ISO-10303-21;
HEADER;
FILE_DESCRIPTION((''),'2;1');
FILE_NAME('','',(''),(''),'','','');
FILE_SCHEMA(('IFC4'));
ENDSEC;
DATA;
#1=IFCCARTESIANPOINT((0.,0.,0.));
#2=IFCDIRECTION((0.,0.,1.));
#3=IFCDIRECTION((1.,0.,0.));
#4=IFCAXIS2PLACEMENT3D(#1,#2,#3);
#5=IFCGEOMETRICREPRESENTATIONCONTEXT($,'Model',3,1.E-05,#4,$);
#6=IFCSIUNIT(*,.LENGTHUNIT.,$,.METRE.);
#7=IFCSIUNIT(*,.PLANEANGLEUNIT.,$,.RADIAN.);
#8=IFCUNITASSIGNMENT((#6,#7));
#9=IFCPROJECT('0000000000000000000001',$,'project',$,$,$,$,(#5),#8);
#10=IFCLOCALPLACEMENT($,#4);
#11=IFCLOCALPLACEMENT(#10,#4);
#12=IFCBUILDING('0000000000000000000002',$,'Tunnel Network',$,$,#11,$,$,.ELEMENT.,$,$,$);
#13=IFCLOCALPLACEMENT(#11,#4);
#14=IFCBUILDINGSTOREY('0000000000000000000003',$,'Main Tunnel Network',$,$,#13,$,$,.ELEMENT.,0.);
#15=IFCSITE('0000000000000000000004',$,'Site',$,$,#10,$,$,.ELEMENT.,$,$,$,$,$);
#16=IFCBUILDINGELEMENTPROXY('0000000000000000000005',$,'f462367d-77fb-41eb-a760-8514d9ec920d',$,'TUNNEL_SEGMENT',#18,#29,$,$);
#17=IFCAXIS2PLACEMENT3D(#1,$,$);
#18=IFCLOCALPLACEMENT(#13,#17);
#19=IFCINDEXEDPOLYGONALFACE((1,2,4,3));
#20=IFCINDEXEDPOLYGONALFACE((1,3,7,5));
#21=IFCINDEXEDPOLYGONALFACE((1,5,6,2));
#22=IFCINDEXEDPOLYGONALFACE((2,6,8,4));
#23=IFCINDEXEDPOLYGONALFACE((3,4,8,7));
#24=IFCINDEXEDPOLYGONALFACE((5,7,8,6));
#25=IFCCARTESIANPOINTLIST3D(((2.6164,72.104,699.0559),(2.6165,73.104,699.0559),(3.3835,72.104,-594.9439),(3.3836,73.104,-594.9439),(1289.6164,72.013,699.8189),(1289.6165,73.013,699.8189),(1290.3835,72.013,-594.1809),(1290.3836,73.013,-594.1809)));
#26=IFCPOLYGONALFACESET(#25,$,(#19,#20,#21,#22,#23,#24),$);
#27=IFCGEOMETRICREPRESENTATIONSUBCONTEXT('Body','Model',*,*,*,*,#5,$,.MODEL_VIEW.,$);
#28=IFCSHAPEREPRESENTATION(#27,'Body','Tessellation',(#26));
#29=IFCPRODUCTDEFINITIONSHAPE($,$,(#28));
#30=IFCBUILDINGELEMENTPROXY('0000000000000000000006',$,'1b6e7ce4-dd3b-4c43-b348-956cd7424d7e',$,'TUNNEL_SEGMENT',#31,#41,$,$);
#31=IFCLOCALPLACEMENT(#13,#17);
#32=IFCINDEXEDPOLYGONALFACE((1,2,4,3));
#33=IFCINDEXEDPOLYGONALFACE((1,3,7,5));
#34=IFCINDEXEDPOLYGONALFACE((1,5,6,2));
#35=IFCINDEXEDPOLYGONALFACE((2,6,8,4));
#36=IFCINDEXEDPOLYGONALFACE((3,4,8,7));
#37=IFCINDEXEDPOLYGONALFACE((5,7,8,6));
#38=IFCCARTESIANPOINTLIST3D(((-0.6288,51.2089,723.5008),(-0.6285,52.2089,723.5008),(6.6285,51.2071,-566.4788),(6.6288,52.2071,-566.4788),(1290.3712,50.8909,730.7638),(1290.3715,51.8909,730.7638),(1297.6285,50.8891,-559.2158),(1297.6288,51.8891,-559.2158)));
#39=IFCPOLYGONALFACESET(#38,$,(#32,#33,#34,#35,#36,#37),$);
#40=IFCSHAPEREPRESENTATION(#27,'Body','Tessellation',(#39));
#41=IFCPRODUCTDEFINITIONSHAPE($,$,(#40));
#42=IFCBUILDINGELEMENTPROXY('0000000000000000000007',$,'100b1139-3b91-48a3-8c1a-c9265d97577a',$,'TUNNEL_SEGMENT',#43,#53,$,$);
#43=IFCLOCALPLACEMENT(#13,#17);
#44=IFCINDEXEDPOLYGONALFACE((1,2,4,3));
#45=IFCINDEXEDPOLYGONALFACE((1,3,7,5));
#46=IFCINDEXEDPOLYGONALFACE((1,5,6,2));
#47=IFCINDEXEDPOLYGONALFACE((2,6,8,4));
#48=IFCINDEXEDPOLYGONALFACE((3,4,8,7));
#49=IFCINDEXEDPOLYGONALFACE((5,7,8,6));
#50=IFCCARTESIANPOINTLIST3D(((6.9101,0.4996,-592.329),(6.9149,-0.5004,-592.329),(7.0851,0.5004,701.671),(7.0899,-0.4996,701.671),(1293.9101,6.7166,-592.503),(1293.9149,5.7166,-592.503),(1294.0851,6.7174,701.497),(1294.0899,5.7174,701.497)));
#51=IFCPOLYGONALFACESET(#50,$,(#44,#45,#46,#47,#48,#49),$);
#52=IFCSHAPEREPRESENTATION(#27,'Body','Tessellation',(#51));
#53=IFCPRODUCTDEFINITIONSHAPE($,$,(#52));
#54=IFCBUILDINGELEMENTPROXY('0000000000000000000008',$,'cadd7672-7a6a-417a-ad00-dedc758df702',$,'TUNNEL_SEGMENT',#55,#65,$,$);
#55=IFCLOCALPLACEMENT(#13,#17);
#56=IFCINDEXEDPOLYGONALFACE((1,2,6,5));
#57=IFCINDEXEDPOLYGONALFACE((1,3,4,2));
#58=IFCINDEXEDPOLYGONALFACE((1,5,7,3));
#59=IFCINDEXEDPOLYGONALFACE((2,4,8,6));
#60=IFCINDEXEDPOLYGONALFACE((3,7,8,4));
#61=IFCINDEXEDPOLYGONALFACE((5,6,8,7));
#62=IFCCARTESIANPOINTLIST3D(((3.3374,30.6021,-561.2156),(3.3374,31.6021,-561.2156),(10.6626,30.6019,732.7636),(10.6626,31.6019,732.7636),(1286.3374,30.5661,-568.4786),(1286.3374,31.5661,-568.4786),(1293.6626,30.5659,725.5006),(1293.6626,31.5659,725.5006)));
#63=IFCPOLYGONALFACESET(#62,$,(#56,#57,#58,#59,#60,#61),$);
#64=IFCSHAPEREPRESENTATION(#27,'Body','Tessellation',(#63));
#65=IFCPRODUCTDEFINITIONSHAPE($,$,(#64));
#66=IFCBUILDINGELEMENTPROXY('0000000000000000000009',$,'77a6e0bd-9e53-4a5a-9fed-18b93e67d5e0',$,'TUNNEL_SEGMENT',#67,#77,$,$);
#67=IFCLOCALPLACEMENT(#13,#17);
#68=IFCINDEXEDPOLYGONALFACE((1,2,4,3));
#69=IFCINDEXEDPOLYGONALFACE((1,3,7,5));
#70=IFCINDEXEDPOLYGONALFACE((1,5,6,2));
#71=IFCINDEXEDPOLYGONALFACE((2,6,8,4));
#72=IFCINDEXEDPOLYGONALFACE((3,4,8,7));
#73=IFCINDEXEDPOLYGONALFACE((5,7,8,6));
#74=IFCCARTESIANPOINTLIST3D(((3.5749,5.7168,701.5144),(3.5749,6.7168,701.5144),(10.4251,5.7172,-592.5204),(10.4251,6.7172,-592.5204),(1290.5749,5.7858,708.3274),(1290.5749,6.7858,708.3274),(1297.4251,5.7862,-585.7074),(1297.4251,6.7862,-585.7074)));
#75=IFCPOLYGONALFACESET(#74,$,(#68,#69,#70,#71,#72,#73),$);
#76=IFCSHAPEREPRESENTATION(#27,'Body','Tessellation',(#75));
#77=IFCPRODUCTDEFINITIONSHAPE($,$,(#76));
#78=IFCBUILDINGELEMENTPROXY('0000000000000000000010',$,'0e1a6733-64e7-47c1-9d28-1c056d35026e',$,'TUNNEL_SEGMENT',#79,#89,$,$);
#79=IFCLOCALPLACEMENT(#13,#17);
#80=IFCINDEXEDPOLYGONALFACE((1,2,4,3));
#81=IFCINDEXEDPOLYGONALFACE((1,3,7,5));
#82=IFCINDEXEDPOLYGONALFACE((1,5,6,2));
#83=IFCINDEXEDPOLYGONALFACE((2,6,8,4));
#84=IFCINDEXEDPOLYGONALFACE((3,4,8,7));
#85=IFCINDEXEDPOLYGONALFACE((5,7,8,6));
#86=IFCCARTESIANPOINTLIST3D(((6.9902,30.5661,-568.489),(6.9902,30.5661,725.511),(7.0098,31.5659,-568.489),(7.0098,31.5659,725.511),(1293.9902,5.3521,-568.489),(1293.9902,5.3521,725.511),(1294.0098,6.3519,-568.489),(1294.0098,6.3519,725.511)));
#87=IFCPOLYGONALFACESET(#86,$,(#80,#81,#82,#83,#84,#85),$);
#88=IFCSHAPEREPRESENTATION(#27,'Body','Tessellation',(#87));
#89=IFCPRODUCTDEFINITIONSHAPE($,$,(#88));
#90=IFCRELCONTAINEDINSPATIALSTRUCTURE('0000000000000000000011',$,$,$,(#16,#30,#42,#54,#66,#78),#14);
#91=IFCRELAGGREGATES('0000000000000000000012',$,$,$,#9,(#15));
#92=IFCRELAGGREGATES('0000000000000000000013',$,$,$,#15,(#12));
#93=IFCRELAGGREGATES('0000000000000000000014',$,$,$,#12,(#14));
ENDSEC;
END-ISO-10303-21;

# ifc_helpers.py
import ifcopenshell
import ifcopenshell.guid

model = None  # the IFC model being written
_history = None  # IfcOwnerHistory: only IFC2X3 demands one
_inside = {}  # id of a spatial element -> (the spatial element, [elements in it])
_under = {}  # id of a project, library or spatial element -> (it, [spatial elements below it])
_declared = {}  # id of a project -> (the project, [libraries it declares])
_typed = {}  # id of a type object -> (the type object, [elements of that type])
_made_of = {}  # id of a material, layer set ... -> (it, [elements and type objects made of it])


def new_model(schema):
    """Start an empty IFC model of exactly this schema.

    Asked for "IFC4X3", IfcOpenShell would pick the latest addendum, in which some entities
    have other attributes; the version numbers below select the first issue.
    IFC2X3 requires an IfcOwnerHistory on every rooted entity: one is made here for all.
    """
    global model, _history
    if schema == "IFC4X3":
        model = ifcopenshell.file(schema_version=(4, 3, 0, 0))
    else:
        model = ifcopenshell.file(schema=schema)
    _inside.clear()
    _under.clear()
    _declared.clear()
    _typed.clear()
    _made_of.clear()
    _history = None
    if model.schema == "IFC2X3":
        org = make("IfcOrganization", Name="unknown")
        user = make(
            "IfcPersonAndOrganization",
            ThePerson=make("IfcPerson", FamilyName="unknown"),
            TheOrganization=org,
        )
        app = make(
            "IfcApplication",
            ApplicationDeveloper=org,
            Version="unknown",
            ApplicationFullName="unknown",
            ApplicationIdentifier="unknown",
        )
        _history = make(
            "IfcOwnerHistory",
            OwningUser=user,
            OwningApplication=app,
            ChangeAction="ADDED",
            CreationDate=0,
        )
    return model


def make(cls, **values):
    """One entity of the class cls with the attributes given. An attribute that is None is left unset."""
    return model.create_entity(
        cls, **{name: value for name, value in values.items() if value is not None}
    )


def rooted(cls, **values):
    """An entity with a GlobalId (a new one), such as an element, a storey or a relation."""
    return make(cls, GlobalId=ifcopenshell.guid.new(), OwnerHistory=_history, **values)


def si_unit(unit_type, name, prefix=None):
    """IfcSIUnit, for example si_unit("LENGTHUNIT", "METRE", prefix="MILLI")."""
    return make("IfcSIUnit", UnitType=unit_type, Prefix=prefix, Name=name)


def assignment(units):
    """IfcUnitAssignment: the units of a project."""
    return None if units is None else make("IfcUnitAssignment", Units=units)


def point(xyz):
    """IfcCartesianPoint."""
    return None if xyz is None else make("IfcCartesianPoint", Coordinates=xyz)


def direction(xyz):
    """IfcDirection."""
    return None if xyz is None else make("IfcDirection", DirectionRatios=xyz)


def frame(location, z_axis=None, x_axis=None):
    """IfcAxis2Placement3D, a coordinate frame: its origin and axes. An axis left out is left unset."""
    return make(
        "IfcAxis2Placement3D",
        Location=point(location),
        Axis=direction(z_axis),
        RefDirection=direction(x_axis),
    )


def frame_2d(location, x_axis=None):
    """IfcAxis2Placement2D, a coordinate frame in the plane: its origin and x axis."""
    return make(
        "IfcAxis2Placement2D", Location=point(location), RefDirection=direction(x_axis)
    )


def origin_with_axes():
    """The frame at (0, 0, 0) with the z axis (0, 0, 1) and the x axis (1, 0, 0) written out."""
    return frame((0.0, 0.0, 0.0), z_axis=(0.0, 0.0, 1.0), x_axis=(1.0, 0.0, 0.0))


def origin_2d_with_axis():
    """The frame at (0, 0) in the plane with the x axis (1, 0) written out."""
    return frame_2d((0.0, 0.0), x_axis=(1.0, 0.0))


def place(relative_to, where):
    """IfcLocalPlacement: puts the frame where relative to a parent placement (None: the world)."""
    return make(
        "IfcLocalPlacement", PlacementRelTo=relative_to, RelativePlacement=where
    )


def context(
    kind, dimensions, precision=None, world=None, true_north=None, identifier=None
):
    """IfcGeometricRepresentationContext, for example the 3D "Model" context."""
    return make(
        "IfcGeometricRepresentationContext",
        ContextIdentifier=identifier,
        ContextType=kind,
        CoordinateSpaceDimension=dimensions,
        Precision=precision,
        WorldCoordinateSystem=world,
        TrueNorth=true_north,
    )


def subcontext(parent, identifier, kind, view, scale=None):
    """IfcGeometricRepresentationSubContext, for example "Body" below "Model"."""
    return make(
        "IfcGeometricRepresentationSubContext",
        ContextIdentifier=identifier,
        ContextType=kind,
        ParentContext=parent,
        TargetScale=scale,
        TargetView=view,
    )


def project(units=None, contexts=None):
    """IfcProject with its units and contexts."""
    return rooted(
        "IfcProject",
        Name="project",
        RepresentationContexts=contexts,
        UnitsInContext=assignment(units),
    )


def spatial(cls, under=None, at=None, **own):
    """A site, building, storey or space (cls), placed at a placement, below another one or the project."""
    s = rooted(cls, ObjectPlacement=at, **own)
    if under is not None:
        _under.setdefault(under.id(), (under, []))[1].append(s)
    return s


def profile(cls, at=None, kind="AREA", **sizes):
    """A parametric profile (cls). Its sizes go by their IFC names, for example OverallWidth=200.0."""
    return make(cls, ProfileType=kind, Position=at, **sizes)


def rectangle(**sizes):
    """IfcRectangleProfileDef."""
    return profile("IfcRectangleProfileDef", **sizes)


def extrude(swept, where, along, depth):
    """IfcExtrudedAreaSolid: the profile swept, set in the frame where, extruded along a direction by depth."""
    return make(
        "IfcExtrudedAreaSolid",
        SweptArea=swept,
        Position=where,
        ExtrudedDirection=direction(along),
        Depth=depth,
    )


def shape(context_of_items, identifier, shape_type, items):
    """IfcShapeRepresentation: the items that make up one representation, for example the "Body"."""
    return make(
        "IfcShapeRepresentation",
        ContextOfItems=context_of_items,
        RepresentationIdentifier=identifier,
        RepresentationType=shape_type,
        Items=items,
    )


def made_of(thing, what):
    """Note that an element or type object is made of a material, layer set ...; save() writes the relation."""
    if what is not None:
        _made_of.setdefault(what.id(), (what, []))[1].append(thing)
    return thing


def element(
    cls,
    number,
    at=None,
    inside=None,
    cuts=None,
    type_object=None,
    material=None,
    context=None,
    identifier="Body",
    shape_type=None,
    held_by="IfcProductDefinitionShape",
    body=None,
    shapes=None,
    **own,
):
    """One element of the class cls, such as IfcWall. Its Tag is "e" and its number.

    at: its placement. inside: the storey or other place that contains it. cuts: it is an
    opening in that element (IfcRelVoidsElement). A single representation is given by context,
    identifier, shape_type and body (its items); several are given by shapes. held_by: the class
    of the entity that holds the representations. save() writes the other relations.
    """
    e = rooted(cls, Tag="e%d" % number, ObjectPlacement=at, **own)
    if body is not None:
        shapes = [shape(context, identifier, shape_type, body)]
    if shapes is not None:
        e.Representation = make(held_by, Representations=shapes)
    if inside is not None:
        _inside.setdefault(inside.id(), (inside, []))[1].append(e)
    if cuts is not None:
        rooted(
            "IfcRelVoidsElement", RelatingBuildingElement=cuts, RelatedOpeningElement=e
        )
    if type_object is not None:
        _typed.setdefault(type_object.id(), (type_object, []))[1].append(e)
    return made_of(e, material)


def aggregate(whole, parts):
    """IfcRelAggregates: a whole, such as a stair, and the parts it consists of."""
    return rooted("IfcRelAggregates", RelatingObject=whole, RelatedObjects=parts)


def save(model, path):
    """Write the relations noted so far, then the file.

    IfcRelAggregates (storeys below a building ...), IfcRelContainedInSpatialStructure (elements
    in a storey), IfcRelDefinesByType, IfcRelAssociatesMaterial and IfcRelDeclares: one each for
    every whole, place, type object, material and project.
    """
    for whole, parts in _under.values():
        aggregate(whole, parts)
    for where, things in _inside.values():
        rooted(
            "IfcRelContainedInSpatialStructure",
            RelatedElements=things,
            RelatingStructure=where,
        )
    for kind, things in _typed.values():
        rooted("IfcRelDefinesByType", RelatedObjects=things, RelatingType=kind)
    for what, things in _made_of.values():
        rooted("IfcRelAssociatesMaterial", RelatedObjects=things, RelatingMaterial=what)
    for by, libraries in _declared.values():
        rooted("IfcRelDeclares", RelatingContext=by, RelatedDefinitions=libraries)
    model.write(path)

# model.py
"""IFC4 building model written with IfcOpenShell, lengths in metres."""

from ifc_helpers import new_model, si_unit, frame, origin_with_axes, origin_2d_with_axis, place, context, subcontext, project, spatial, rectangle, extrude, element, save


model = new_model("IFC4")

# Units and contexts
model_context = context("Model", 3, precision=1e-05, world=origin_with_axes())
body_context = subcontext(model_context, "Body", "Model", "MODEL_VIEW")
ifc_project = project(units=[si_unit("LENGTHUNIT", "METRE"), si_unit("PLANEANGLEUNIT", "RADIAN")], contexts=[model_context])

# Site, building, storey
site_placement = place(None, origin_with_axes())
site = spatial("IfcSite", under=ifc_project, at=site_placement, Name="Site", CompositionType="ELEMENT")
building_placement = place(site_placement, origin_with_axes())
building = spatial("IfcBuilding", under=site, at=building_placement, Name="Tunnel Network", CompositionType="ELEMENT")
storey_placement = place(building_placement, origin_with_axes())
storey = spatial("IfcBuildingStorey", under=building, at=storey_placement, Name="Main Tunnel Network", CompositionType="ELEMENT", Elevation=0.0)

# Building element proxies
proxy_1_placement = place(storey_placement, frame((3.0, 72.604, 52.056), z_axis=(1.0, -0.000071, 0.000593), x_axis=(-0.000593, 0.0, 1.0)))
element("IfcBuildingElementProxy", 1, at=proxy_1_placement, inside=storey, Name="f462367d-77fb-41eb-a760-8514d9ec920d", ObjectType="TUNNEL_SEGMENT", context=body_context, shape_type="SweptSolid", body=[
    extrude(rectangle(XDim=1294.0, YDim=1.0, at=origin_2d_with_axis()), origin_with_axes(), (0.0, 0.0, 1.0), 1287.0002),
])
proxy_2_placement = place(storey_placement, frame((3.0, 51.708, 78.511), z_axis=(0.999984, -0.000246, 0.005626), x_axis=(-0.005626, 0.000001, 0.999984)))
element("IfcBuildingElementProxy", 2, at=proxy_2_placement, inside=storey, Name="1b6e7ce4-dd3b-4c43-b348-956cd7424d7e", ObjectType="TUNNEL_SEGMENT", context=body_context, shape_type="SweptSolid", body=[
    extrude(rectangle(XDim=1290.0, YDim=1.0, at=origin_2d_with_axis()), origin_with_axes(), (0.0, 0.0, 1.0), 1291.0205),
])
proxy_3_placement = place(storey_placement, frame((7.0, 0.0, 54.671), z_axis=(0.999988, 0.004831, -0.000135), x_axis=(0.000135, 0.000001, 1.0)))
element("IfcBuildingElementProxy", 3, at=proxy_3_placement, inside=storey, Name="100b1139-3b91-48a3-8c1a-c9265d97577a", ObjectType="TUNNEL_SEGMENT", context=body_context, shape_type="SweptSolid", body=[
    extrude(rectangle(XDim=1294.0, YDim=1.0, at=origin_2d_with_axis()), origin_with_axes(), (0.0, 0.0, 1.0), 1287.015),
])
proxy_4_placement = place(storey_placement, frame((7.0, 31.102, 85.774), z_axis=(0.999984, -0.000028, -0.005661), x_axis=(0.005661, 0.0, 0.999984)))
element("IfcBuildingElementProxy", 4, at=proxy_4_placement, inside=storey, Name="cadd7672-7a6a-417a-ad00-dedc758df702", ObjectType="TUNNEL_SEGMENT", context=body_context, shape_type="SweptSolid", body=[
    extrude(rectangle(XDim=1294.0, YDim=1.0, at=origin_2d_with_axis()), origin_with_axes(), (0.0, 0.0, 1.0), 1283.0206),
])
proxy_5_placement = place(storey_placement, frame((7.0, 6.217, 54.497), z_axis=(0.999986, 0.000054, 0.005294), x_axis=(-0.005294, 0.0, 0.999986)))
element("IfcBuildingElementProxy", 5, at=proxy_5_placement, inside=storey, Name="77a6e0bd-9e53-4a5a-9fed-18b93e67d5e0", ObjectType="TUNNEL_SEGMENT", context=body_context, shape_type="SweptSolid", body=[
    extrude(rectangle(XDim=1294.053, YDim=1.0, at=origin_2d_with_axis()), origin_with_axes(), (0.0, 0.0, 1.0), 1287.018),
])
proxy_6_placement = place(storey_placement, frame((7.0, 31.066, 78.511), z_axis=(0.999808, -0.019588, 0.0), x_axis=(0.0, 0.0, 1.0)))
element("IfcBuildingElementProxy", 6, at=proxy_6_placement, inside=storey, Name="0e1a6733-64e7-47c1-9d28-1c056d35026e", ObjectType="TUNNEL_SEGMENT", context=body_context, shape_type="SweptSolid", body=[
    extrude(rectangle(XDim=1294.0, YDim=1.0, at=origin_2d_with_axis()), origin_with_axes(), (0.0, 0.0, 1.0), 1287.247),
])

save(model, "model.ifc")
